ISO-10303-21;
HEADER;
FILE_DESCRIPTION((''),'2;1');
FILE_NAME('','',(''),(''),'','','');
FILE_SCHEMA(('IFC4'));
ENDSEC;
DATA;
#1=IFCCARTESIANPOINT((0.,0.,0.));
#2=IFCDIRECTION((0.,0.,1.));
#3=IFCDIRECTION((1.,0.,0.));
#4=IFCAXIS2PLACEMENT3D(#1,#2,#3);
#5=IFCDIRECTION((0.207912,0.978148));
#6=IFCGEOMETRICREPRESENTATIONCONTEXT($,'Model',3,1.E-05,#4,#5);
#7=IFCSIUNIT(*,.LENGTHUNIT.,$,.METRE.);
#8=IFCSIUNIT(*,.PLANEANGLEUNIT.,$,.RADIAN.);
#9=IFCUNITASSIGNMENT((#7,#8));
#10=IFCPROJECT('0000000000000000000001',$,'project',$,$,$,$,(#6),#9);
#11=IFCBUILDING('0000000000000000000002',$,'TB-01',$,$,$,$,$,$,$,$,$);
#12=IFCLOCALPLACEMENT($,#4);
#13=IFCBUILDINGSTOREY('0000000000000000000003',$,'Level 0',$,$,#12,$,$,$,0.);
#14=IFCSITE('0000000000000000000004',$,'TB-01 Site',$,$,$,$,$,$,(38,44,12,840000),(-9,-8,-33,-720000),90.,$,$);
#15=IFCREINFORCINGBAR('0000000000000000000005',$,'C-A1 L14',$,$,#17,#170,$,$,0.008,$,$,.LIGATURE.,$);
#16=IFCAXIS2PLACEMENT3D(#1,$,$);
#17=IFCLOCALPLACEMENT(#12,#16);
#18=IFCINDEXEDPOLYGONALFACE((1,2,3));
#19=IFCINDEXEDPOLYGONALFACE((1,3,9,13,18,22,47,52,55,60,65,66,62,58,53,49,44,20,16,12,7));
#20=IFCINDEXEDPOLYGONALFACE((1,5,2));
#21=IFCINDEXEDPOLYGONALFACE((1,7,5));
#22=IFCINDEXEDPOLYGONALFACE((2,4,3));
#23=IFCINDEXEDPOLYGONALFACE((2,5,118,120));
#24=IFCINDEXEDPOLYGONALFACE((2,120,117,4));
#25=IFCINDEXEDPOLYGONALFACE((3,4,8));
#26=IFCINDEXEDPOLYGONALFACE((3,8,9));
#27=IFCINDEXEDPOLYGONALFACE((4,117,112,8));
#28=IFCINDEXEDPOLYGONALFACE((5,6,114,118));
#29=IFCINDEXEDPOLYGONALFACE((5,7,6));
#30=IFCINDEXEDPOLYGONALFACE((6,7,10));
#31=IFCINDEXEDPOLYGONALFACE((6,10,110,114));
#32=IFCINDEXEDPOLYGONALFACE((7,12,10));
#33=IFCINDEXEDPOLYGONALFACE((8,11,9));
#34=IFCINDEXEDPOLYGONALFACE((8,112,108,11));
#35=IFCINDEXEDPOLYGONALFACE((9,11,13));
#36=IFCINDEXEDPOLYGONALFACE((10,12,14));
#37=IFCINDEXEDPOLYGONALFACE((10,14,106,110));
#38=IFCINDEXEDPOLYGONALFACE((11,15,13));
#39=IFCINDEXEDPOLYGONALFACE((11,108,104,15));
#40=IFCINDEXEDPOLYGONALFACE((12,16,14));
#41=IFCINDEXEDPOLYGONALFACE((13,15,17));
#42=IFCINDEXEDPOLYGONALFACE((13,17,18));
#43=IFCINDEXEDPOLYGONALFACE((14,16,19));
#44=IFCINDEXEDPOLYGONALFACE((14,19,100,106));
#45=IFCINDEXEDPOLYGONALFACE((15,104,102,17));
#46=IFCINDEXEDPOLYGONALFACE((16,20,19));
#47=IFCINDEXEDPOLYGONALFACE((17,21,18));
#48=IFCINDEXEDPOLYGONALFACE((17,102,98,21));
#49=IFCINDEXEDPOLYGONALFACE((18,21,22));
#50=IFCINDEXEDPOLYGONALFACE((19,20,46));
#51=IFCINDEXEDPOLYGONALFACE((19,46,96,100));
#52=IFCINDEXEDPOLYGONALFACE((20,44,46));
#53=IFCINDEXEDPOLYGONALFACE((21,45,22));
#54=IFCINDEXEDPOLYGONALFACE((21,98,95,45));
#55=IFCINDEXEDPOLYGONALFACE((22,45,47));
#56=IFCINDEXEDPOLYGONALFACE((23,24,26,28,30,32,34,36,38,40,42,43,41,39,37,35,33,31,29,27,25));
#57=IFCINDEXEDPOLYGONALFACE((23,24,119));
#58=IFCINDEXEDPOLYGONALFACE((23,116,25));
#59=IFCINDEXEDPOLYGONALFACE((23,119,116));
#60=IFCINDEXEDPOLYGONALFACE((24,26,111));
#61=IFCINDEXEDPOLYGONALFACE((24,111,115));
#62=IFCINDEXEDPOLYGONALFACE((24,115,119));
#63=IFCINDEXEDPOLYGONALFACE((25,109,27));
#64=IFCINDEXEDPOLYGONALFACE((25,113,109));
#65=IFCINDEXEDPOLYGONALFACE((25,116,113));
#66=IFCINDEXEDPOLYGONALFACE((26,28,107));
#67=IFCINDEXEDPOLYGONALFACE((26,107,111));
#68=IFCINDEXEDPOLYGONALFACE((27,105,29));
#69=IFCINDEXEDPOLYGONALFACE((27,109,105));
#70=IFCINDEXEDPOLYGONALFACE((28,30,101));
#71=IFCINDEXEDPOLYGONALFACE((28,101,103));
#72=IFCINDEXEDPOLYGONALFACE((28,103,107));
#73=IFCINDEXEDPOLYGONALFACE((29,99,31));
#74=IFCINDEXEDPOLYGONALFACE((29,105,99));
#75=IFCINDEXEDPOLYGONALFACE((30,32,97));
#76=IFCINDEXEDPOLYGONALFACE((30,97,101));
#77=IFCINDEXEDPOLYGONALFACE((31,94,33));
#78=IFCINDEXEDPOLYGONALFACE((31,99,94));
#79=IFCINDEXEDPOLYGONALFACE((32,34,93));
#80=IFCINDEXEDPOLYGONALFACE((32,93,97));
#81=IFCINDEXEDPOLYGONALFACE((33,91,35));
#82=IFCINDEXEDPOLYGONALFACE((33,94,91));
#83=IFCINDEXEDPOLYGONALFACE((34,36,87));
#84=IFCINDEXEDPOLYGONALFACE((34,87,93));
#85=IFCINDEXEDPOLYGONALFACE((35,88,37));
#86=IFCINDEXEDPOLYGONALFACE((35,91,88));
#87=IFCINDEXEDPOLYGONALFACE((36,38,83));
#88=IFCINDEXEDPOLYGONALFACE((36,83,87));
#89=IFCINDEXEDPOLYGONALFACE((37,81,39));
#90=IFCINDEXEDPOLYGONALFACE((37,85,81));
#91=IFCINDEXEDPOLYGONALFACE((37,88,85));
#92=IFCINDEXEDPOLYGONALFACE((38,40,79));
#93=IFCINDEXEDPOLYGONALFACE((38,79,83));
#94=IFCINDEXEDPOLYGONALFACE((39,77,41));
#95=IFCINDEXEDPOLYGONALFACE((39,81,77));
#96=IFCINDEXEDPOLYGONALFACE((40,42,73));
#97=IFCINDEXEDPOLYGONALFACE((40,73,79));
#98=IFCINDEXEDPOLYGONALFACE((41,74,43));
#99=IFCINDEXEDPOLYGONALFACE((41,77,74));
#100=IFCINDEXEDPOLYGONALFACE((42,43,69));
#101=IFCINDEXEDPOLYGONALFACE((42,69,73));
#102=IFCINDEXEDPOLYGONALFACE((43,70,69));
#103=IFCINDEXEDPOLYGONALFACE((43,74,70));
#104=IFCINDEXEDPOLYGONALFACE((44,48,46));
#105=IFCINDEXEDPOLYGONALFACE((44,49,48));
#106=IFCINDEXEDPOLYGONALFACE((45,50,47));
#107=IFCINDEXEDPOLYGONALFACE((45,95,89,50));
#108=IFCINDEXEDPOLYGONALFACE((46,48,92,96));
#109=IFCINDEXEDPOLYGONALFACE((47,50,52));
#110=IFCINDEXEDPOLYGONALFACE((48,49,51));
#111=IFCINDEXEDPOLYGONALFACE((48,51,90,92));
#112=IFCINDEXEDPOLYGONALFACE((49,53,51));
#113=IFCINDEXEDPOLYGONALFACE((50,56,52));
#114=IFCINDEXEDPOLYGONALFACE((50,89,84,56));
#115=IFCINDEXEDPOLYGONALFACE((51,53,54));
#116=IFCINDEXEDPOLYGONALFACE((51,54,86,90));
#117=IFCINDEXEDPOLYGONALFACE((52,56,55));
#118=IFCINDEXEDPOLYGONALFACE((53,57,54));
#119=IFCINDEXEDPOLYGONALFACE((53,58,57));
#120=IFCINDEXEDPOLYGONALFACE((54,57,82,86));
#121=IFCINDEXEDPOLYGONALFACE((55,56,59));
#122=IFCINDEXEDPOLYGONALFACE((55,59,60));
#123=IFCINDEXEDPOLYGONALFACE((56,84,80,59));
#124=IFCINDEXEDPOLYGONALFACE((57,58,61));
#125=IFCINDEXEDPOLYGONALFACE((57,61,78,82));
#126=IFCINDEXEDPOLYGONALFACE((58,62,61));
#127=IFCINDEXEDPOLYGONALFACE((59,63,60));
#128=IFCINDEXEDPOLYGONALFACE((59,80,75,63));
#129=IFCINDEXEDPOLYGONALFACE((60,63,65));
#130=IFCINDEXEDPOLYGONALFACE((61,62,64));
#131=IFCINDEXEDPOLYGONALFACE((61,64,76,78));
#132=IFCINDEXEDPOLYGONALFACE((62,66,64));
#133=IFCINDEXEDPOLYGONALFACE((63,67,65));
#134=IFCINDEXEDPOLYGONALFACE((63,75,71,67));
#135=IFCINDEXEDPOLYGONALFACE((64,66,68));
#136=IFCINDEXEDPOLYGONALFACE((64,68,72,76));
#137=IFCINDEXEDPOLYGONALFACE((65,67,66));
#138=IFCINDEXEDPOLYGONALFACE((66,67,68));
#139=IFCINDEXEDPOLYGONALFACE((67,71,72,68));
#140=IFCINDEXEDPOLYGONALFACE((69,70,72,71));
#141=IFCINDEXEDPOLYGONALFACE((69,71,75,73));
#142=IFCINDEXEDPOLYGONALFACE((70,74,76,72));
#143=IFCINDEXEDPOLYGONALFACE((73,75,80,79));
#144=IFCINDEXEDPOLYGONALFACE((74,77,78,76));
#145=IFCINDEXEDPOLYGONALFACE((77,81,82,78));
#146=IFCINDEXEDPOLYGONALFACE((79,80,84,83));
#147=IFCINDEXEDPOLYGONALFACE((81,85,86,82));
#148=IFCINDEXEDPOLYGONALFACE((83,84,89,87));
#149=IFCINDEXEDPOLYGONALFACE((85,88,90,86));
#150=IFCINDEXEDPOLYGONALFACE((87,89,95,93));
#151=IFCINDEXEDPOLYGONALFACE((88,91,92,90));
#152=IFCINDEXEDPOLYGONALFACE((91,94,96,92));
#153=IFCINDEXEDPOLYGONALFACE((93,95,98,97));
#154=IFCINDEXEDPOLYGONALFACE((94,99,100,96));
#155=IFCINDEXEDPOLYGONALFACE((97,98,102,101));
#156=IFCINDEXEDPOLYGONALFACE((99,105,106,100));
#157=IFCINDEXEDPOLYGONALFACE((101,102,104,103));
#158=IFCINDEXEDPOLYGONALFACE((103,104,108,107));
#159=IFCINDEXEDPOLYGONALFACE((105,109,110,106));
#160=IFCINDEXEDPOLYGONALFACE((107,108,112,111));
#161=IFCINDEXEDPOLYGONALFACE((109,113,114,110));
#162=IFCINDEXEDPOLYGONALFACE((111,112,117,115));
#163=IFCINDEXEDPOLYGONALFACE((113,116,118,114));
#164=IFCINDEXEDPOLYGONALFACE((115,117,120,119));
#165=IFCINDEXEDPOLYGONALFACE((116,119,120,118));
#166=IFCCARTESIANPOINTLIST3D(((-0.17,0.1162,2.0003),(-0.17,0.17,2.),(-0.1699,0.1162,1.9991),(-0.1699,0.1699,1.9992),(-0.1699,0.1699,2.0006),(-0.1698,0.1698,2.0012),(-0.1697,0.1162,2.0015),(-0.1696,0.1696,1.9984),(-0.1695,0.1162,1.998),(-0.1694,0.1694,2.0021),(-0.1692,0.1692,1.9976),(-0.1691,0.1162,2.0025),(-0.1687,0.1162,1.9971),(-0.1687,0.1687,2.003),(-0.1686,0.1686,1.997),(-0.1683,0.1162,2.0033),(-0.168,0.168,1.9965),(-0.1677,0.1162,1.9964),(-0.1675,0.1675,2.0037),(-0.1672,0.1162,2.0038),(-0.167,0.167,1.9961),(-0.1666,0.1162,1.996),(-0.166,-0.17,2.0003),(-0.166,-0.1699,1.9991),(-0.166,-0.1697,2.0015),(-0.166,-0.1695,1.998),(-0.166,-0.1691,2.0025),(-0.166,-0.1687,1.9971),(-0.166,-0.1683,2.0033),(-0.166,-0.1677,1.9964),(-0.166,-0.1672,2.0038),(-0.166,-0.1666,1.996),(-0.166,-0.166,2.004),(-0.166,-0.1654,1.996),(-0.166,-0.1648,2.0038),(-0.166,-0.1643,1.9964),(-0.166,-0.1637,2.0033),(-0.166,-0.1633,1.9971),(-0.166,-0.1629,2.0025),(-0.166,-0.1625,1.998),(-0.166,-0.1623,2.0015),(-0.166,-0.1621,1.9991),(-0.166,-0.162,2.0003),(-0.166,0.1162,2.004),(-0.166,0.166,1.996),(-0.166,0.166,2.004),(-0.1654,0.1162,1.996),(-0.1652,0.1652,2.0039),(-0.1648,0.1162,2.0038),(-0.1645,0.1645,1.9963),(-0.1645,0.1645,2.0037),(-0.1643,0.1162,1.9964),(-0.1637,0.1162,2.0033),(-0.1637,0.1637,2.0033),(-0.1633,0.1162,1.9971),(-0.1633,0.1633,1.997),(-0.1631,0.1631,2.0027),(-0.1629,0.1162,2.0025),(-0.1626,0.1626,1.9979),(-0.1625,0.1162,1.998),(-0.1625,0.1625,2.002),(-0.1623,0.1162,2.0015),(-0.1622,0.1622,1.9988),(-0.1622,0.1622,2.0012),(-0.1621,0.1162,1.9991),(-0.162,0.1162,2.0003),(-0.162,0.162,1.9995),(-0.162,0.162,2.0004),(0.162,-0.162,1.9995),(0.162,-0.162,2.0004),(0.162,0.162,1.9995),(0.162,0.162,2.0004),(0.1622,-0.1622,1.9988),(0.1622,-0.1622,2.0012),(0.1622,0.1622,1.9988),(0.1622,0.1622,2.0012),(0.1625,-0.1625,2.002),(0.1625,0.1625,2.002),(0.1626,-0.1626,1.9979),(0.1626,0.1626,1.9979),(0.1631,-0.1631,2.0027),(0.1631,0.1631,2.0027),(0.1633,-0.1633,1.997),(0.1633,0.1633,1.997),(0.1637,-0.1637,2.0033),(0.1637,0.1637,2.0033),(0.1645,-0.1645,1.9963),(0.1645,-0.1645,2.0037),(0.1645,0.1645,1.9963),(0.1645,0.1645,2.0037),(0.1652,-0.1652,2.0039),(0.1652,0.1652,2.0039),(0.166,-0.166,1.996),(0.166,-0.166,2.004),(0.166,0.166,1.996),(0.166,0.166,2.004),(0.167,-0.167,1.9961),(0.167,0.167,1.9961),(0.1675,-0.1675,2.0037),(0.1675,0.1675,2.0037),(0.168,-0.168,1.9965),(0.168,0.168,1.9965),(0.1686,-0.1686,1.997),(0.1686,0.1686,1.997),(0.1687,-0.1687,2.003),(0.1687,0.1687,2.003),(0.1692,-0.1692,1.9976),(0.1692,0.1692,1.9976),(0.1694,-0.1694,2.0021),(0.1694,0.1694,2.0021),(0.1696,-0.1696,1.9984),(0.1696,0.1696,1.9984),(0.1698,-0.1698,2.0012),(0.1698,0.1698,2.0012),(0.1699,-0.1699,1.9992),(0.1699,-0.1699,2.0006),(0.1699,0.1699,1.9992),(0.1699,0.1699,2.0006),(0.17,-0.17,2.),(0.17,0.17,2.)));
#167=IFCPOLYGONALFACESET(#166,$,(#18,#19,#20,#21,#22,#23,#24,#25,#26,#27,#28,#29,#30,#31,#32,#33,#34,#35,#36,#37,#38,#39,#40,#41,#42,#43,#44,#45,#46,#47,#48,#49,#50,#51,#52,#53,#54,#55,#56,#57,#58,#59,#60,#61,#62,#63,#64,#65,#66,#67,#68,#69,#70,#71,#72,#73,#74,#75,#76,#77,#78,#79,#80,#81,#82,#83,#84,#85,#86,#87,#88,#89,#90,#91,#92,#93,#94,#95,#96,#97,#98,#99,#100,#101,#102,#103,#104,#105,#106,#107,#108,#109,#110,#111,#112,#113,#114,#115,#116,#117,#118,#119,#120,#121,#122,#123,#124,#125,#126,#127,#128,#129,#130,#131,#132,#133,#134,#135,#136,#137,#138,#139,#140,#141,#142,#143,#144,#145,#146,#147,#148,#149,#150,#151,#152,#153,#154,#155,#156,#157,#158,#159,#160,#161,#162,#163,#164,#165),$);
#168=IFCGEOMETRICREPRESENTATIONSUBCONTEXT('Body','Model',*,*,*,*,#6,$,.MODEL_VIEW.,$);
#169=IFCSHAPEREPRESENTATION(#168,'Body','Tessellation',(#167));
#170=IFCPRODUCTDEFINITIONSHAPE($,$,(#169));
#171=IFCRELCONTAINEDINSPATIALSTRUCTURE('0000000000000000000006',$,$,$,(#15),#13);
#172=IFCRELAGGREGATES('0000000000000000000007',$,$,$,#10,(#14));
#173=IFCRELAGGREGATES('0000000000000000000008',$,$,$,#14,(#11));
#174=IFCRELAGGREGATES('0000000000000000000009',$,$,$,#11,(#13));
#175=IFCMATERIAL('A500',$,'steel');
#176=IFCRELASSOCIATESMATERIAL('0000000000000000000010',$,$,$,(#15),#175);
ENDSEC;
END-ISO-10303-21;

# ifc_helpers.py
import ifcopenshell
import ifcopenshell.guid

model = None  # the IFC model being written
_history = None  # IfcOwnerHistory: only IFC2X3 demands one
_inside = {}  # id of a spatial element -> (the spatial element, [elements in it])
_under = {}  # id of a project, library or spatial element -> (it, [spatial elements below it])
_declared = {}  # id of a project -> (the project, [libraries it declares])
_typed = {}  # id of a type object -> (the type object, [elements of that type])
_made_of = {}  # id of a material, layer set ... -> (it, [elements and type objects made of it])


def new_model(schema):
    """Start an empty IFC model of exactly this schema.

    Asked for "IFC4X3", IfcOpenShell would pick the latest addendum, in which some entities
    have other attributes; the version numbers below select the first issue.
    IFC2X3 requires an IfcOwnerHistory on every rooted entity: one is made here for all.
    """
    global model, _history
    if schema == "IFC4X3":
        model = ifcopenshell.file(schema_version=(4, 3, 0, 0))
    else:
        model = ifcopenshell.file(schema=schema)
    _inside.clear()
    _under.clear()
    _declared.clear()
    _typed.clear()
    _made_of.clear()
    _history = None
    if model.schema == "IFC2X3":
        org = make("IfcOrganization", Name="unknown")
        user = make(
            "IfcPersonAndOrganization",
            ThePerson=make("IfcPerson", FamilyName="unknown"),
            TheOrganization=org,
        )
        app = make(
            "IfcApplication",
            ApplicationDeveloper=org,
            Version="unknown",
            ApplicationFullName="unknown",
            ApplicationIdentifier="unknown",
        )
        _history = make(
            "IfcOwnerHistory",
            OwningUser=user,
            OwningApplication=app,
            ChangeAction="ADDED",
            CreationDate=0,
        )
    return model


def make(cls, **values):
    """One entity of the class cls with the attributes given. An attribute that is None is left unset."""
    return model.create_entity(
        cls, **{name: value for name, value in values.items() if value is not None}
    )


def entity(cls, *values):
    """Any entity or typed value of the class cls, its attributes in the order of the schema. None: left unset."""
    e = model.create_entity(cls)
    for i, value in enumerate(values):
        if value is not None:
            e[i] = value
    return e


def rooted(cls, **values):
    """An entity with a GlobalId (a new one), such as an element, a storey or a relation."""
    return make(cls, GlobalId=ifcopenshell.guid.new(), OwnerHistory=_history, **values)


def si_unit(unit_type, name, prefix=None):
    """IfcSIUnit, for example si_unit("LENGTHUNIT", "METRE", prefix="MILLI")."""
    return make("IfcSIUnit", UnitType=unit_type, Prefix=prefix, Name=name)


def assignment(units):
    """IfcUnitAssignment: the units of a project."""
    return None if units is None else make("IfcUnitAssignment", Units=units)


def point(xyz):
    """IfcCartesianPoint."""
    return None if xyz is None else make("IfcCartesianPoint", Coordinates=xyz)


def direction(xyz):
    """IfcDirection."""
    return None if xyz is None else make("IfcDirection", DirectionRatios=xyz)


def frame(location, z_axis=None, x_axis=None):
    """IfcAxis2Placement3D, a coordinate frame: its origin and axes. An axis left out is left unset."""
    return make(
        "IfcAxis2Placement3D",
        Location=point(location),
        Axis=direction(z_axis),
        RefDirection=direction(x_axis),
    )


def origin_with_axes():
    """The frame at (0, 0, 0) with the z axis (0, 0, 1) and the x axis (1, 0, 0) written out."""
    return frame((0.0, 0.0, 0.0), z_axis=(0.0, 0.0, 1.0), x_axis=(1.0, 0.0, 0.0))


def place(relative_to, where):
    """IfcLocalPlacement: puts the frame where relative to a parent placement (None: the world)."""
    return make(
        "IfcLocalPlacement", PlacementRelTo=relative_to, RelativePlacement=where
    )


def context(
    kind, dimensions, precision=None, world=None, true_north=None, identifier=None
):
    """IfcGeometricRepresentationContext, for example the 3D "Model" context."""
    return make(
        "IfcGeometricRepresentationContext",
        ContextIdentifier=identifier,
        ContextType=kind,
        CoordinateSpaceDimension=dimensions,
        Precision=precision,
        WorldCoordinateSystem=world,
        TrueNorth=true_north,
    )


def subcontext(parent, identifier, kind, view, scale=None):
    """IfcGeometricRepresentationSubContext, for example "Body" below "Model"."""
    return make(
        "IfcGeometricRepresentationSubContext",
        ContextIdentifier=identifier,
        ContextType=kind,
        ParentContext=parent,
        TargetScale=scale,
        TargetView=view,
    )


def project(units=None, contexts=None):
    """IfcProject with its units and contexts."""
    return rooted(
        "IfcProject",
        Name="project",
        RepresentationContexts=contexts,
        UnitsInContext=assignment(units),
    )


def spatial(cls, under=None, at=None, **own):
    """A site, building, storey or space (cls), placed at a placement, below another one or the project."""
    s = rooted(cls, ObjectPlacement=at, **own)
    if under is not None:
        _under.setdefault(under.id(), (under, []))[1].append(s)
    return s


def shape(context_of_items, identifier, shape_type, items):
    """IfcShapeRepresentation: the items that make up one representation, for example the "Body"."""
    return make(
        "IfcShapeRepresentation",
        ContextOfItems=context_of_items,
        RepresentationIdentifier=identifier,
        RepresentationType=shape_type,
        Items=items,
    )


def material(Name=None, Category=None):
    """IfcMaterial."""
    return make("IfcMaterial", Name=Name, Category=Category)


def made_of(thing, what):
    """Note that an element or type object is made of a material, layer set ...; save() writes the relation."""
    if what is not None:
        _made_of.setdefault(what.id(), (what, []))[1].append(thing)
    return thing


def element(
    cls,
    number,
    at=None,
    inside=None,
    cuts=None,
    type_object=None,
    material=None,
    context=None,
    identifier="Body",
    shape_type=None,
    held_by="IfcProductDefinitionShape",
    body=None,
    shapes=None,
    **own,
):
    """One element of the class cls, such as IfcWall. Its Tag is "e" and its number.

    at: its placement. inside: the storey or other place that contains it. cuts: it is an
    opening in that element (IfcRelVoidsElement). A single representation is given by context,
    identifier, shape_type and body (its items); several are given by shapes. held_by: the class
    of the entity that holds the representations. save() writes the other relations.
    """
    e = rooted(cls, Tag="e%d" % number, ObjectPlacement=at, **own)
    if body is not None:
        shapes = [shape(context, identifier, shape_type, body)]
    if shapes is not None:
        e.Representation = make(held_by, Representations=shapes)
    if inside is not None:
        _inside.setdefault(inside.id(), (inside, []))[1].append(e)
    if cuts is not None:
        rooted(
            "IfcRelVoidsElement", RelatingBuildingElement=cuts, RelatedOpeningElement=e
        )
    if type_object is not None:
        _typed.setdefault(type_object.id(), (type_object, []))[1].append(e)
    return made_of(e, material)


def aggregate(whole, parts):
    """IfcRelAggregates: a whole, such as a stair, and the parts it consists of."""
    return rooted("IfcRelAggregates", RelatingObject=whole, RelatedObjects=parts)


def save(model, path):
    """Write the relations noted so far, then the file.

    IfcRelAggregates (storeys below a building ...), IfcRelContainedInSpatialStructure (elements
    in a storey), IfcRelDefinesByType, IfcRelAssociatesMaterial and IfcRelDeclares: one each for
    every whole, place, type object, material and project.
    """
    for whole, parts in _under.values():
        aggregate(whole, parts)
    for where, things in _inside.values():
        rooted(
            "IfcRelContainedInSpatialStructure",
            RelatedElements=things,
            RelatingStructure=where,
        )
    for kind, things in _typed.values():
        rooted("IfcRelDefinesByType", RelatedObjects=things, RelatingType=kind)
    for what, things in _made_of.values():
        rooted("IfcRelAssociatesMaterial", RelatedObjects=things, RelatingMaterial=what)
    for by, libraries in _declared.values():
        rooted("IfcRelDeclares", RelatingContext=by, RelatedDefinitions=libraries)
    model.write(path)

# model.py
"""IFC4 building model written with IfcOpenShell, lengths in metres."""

from ifc_helpers import new_model, entity, si_unit, direction, origin_with_axes, place, context, subcontext, project, spatial, material, element, save


model = new_model("IFC4")

# Units and contexts
model_context = context("Model", 3, precision=1e-05, world=origin_with_axes(), true_north=direction((0.207912, 0.978148)))
body_context = subcontext(model_context, "Body", "Model", "MODEL_VIEW")
ifc_project = project(units=[si_unit("LENGTHUNIT", "METRE"), si_unit("PLANEANGLEUNIT", "RADIAN")], contexts=[model_context])

# Site, building, storey
site = spatial("IfcSite", under=ifc_project, Name="TB-01 Site", RefLatitude=(38, 44, 12, 840000), RefLongitude=(-9, -8, -33, -720000), RefElevation=90.0)
building = spatial("IfcBuilding", under=site, Name="TB-01")
storey_placement = place(None, origin_with_axes())
storey = spatial("IfcBuildingStorey", under=building, at=storey_placement, Name="Level 0", Elevation=0.0)

# Reinforcing bar
ifc_material_1 = material(Name="A500", Category="steel")
reinforcing_bar_1_placement = place(storey_placement, origin_with_axes())
element("IfcReinforcingBar", 1, at=reinforcing_bar_1_placement, inside=storey, material=ifc_material_1, Name="C-A1 L14", NominalDiameter=0.008, PredefinedType="LIGATURE", context=body_context, shape_type="AdvancedSweptSolid", body=[
    entity("IfcSweptDiskSolid", entity("IfcPolyline", [entity("IfcCartesianPoint", [-0.166, -0.166, 2.0]), entity("IfcCartesianPoint", [0.166, -0.166, 2.0]), entity("IfcCartesianPoint", [0.166, 0.166, 2.0]), entity("IfcCartesianPoint", [-0.166, 0.166, 2.0]), entity("IfcCartesianPoint", [-0.166, 0.1162, 2.0])]), 0.004),
])

save(model, "model.ifc")
